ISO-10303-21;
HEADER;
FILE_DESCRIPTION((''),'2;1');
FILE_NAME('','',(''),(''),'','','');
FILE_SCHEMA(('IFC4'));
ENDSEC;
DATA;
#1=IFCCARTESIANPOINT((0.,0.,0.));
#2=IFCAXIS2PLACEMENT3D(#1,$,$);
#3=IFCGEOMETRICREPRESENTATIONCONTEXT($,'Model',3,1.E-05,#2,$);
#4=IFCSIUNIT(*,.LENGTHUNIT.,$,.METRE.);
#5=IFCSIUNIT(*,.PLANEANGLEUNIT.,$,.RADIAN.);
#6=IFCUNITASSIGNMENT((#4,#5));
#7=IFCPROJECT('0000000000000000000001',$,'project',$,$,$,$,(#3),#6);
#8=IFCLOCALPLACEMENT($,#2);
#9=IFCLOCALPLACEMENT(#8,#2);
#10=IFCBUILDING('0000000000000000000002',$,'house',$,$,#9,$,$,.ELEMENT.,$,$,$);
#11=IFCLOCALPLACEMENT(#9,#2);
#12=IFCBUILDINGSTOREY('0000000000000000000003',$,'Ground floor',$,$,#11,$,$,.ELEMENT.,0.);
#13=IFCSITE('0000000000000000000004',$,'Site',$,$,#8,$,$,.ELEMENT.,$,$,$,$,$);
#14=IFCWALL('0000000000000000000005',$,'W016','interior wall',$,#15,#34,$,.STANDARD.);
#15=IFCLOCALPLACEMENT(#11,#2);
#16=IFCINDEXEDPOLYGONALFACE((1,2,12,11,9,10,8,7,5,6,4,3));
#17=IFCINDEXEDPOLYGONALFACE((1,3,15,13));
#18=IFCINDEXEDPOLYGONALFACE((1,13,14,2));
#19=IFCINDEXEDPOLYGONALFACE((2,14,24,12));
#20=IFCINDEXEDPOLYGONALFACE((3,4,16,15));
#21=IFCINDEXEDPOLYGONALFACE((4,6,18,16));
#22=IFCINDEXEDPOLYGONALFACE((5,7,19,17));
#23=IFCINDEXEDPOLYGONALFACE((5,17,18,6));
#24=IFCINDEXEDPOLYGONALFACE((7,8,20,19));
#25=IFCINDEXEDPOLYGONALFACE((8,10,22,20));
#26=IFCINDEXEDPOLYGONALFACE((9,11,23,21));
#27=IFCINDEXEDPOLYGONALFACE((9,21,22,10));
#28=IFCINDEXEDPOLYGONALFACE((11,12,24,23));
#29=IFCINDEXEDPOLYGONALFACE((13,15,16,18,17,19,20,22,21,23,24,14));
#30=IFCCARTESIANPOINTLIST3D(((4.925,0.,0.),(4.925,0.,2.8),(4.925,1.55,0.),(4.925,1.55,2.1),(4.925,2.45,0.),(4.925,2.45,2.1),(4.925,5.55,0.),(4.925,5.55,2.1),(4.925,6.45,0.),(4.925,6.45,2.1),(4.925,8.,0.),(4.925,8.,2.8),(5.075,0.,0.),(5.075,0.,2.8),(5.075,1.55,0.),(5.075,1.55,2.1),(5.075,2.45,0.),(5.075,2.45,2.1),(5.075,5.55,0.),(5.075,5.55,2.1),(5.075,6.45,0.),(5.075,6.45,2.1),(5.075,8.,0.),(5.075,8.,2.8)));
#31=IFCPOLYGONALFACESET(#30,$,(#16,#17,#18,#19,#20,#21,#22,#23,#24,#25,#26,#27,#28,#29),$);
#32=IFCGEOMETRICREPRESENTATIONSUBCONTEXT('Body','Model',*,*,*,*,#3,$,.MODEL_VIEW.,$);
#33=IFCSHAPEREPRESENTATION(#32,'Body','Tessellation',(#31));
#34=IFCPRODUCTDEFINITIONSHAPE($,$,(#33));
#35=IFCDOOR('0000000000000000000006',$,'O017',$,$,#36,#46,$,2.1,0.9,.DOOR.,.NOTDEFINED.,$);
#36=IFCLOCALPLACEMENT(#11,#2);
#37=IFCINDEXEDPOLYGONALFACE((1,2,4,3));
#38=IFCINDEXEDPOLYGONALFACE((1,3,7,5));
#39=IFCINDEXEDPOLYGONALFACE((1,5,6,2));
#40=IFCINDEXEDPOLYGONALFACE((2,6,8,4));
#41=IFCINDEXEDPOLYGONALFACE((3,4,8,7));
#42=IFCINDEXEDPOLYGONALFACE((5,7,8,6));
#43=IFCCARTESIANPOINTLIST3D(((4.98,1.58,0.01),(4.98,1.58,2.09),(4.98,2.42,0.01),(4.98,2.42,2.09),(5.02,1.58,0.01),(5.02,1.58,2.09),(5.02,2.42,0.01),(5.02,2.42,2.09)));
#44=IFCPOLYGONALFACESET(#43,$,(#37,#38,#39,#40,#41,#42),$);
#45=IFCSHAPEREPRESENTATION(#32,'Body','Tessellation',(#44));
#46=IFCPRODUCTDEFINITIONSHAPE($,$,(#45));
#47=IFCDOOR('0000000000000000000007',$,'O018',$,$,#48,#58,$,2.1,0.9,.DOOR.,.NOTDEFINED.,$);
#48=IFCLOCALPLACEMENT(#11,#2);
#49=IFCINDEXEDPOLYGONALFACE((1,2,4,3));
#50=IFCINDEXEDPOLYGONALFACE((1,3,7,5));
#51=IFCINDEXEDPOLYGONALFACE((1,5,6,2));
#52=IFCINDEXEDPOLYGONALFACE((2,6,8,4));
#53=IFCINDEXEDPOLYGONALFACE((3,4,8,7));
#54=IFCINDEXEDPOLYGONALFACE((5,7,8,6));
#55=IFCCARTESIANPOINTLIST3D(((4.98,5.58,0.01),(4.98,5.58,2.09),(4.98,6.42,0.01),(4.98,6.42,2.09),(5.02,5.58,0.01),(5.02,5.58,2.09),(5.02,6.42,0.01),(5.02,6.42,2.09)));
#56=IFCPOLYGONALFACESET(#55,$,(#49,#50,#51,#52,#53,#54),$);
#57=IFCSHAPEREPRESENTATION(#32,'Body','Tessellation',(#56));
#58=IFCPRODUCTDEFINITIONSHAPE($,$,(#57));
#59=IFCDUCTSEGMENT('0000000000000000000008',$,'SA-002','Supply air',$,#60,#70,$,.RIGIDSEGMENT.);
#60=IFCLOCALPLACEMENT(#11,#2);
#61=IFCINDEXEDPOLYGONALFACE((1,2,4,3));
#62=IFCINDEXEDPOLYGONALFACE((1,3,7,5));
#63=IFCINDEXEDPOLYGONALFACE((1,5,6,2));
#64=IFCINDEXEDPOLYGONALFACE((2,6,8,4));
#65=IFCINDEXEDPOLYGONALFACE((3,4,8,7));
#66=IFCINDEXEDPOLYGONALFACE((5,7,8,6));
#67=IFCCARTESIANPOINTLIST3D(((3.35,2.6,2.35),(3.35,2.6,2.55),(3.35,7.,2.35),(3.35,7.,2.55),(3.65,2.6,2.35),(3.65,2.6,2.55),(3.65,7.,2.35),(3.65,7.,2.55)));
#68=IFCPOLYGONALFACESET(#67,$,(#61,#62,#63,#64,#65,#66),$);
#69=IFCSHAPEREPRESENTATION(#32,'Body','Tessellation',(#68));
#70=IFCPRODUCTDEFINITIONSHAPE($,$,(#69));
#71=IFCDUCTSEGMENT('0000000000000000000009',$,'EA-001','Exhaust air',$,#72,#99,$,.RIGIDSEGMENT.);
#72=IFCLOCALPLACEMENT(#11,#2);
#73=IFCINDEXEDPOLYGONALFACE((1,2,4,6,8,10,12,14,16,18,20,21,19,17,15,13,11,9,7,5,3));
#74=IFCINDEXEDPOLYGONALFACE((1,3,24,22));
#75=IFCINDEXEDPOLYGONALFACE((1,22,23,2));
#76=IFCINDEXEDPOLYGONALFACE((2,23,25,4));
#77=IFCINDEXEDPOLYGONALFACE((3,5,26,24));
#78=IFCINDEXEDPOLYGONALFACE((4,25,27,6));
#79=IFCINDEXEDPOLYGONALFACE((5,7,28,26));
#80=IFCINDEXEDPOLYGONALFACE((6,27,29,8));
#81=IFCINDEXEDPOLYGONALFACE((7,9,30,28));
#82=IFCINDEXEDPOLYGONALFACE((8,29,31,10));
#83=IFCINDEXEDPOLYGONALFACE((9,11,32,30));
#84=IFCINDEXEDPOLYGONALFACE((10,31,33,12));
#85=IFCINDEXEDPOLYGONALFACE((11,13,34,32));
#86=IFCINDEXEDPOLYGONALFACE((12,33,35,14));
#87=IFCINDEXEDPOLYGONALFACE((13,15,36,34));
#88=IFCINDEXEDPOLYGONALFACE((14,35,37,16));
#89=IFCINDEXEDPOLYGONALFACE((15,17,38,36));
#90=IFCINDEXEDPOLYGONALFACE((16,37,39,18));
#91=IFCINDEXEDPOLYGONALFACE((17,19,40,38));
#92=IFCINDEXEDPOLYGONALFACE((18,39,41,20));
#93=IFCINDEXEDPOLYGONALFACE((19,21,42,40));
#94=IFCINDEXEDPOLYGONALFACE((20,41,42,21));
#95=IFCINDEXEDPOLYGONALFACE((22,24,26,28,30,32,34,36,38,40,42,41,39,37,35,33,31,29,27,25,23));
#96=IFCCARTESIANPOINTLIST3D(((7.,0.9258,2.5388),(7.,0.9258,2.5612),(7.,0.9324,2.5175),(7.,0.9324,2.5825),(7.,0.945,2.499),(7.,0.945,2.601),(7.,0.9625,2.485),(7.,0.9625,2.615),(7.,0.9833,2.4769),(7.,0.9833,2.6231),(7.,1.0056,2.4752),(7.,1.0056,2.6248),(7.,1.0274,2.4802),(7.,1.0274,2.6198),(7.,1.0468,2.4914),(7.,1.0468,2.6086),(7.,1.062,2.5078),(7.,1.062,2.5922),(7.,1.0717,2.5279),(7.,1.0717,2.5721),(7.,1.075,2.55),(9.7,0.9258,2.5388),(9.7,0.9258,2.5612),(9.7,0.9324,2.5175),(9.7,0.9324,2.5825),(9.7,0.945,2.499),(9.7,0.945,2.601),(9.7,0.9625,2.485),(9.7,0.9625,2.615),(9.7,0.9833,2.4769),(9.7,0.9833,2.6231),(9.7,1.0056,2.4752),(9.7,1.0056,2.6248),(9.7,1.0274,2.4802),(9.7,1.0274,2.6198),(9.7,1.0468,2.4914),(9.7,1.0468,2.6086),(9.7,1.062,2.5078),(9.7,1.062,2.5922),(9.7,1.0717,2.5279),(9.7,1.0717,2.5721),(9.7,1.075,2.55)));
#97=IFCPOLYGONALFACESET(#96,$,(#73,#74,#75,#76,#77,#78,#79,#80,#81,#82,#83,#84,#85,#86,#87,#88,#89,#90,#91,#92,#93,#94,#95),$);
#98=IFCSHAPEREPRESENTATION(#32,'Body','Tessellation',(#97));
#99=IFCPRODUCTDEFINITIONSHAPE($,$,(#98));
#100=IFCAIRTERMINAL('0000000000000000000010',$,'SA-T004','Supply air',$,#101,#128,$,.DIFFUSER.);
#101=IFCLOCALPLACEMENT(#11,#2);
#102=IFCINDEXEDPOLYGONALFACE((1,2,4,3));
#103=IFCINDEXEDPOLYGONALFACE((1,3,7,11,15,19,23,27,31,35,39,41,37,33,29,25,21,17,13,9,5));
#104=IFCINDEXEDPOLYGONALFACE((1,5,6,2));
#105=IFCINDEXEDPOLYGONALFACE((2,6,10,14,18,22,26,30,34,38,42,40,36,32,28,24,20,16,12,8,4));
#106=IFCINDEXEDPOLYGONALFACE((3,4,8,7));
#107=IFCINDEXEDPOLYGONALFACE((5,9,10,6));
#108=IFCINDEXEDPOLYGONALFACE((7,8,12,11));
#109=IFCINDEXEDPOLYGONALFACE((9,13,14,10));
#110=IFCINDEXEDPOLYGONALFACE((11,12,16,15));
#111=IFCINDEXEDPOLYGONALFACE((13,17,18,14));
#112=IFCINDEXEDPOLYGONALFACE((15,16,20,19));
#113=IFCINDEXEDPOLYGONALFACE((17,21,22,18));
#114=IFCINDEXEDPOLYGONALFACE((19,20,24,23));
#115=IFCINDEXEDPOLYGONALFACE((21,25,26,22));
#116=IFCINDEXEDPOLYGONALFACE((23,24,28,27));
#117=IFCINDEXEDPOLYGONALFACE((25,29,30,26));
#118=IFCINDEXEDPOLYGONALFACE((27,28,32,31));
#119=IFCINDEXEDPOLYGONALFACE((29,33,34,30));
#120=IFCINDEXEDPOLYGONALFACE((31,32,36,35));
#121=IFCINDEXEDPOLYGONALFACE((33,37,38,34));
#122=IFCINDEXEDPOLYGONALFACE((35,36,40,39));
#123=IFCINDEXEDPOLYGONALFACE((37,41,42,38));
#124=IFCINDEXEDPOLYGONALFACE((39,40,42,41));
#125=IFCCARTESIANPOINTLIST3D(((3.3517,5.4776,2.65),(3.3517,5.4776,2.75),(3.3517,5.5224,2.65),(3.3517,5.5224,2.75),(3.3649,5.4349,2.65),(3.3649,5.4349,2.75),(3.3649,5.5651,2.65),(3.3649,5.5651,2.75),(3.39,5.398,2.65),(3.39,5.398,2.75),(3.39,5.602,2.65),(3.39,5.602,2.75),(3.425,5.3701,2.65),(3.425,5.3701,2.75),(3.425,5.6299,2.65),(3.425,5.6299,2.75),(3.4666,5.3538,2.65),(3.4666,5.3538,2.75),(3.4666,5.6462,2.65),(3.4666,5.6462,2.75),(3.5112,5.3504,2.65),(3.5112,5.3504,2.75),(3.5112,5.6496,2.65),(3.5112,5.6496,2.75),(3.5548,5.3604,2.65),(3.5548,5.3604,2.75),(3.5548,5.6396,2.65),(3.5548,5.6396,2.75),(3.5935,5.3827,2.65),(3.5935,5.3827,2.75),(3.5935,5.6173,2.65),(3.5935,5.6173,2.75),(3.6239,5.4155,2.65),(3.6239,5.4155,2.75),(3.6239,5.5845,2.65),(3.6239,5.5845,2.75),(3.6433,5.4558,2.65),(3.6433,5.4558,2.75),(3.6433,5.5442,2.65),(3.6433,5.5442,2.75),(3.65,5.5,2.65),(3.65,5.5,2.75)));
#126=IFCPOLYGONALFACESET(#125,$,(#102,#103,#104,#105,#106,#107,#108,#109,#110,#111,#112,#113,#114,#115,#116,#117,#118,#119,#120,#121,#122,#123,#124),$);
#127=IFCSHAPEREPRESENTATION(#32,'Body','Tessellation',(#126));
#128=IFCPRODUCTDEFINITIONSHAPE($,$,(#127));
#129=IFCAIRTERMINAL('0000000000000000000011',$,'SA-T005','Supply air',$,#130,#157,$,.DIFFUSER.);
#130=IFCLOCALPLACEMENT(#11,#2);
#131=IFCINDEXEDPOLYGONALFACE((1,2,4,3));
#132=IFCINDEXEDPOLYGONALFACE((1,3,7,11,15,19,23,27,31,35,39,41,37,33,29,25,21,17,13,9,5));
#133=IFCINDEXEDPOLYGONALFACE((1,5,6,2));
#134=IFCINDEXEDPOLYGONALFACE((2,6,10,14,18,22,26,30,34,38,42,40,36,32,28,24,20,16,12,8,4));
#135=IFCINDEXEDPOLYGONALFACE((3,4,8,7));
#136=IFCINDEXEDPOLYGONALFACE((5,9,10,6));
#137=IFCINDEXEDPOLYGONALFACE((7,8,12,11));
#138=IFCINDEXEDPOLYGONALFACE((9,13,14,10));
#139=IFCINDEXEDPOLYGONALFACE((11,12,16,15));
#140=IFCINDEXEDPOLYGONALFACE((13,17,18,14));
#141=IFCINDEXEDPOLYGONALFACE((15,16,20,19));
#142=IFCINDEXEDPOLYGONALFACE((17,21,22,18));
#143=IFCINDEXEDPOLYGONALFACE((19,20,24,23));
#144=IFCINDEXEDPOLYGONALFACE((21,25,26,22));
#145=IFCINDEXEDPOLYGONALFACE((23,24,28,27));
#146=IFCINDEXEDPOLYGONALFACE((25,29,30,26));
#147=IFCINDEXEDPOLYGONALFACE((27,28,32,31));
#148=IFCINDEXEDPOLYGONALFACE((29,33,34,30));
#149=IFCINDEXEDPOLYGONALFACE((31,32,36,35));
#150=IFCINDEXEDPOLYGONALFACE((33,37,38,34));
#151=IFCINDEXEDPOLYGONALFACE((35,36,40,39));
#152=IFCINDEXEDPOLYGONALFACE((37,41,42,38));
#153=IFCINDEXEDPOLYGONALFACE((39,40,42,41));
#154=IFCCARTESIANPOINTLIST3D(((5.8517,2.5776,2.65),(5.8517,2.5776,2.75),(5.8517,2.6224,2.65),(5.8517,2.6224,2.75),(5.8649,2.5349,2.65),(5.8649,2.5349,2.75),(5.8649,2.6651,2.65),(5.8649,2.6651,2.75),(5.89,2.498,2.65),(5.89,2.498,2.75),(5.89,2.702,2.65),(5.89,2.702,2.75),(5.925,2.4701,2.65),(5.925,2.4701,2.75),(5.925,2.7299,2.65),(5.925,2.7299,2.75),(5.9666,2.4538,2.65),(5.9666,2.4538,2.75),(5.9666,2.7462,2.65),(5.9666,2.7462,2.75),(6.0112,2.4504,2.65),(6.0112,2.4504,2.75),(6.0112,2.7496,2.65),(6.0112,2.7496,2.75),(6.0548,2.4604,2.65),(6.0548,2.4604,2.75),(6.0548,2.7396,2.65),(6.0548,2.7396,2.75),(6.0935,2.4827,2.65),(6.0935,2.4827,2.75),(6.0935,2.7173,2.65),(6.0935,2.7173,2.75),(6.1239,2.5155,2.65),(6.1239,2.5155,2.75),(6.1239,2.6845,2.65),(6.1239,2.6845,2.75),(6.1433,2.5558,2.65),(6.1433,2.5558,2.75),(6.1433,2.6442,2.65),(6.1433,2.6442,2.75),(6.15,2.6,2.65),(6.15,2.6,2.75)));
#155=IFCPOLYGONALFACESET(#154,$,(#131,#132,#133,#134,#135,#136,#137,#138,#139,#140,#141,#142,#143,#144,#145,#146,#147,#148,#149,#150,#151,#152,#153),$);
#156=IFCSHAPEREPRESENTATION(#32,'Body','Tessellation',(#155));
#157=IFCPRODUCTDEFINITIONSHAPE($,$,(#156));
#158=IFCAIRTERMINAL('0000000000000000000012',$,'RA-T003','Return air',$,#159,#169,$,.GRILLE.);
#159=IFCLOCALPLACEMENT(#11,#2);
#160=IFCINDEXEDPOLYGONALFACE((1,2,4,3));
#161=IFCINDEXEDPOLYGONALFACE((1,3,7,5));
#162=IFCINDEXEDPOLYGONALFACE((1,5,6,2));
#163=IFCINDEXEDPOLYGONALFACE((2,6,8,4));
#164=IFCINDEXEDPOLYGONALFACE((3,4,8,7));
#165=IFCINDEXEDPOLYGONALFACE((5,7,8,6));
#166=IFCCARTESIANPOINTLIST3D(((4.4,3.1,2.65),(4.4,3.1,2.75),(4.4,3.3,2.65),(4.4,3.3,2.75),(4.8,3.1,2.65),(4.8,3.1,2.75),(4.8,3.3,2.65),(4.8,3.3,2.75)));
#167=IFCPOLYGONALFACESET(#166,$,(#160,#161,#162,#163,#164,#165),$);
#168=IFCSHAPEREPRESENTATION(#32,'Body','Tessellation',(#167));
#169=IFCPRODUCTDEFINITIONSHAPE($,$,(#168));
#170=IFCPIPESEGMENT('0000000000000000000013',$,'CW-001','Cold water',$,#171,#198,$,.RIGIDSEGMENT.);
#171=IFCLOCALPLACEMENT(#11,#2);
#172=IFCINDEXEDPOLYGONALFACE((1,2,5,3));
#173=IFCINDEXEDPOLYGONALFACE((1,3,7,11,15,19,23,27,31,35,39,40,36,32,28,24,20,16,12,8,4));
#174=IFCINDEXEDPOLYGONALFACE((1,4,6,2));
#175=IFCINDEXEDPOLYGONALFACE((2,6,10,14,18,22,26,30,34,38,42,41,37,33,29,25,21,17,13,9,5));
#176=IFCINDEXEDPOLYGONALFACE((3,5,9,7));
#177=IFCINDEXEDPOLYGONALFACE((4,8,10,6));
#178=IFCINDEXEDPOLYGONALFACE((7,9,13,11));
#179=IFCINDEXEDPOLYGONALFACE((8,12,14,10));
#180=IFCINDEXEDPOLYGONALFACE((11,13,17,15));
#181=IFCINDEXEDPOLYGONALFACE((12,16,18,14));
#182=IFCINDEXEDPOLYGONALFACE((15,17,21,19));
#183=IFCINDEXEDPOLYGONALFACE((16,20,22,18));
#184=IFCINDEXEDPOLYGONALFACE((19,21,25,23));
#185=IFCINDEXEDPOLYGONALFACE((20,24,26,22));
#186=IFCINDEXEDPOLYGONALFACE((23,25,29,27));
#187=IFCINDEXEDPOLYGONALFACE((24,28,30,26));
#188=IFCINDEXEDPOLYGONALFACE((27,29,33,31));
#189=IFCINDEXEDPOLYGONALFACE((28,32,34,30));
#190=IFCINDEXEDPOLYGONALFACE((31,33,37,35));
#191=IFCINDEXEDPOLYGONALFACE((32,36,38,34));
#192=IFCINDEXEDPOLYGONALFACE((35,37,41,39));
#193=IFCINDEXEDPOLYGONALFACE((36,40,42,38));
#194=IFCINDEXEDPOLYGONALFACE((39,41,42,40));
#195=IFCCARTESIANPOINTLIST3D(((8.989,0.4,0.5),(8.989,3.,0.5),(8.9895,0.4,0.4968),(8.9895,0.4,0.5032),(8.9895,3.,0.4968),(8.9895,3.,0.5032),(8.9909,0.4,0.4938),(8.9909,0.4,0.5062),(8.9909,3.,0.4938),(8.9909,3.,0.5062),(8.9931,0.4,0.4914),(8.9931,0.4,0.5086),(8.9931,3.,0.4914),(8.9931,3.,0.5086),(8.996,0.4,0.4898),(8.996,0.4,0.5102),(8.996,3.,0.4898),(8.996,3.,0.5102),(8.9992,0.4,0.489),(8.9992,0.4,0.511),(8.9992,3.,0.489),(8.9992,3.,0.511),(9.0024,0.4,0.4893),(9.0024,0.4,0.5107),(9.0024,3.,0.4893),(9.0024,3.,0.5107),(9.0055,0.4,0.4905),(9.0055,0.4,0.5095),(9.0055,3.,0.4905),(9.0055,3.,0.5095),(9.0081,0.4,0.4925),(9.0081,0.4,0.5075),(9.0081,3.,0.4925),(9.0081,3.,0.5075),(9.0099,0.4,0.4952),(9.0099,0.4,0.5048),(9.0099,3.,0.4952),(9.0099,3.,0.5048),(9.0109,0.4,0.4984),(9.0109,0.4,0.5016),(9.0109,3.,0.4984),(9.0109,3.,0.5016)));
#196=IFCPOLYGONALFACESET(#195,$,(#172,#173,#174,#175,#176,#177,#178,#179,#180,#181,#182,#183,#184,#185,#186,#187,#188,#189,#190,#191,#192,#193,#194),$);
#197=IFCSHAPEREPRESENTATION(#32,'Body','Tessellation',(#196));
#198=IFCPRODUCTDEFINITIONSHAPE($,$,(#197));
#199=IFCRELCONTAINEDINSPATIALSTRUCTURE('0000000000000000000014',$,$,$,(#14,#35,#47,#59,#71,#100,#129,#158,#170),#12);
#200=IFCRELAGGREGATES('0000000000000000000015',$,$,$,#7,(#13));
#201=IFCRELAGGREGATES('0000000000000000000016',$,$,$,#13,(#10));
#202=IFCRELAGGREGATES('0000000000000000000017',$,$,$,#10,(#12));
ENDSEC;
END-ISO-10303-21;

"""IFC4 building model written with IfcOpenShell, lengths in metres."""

from ifc_helpers import new_model, si_unit, frame, origin, origin_2d, place, context, subcontext, project, spatial, rectangle, circle, extrude, element, fill, save


model = new_model("IFC4")

# Units and contexts
model_context = context("Model", 3, precision=1e-05, world=origin())
body_context = subcontext(model_context, "Body", "Model", "MODEL_VIEW")
ifc_project = project(units=[si_unit("LENGTHUNIT", "METRE"), si_unit("PLANEANGLEUNIT", "RADIAN")], contexts=[model_context])

# Site, building, storey
site_placement = place(None, origin())
site = spatial("IfcSite", under=ifc_project, at=site_placement, Name="Site", CompositionType="ELEMENT")
building_placement = place(site_placement, origin())
building = spatial("IfcBuilding", under=site, at=building_placement, Name="house", CompositionType="ELEMENT")
storey_placement = place(building_placement, origin())
storey = spatial("IfcBuildingStorey", under=building, at=storey_placement, Name="Ground floor", CompositionType="ELEMENT", Elevation=0.0)

# Wall, openings, doors
wall_1_placement = place(storey_placement, frame((5.0, 4.0, 0.0), z_axis=(0.0, 0.0, 1.0), x_axis=(0.0, 1.0, 0.0)))
wall_1 = element("IfcWall", 1, at=wall_1_placement, inside=storey, Name="W016", Description="interior wall", PredefinedType="STANDARD", context=body_context, shape_type="SweptSolid", body=[
    extrude(rectangle(XDim=8.0, YDim=0.15, at=origin_2d()), origin(), (0.0, 0.0, 1.0), 2.8),
])
opening_1_placement = place(wall_1_placement, frame((-2.0, 0.0, 0.0)))
opening_1 = element("IfcOpeningElement", 2, at=opening_1_placement, cuts=wall_1, PredefinedType="OPENING", context=body_context, shape_type="SweptSolid", body=[
    extrude(rectangle(XDim=0.9, YDim=0.18, at=origin_2d()), origin(), (0.0, 0.0, 1.0), 2.1),
])
opening_2_placement = place(wall_1_placement, frame((2.0, 0.0, 0.0)))
opening_2 = element("IfcOpeningElement", 3, at=opening_2_placement, cuts=wall_1, PredefinedType="OPENING", context=body_context, shape_type="SweptSolid", body=[
    extrude(rectangle(XDim=0.9, YDim=0.18, at=origin_2d()), origin(), (0.0, 0.0, 1.0), 2.1),
])
door_1_placement = place(wall_1_placement, frame((-2.0, 0.0, 0.0)))
door_1 = element("IfcDoor", 4, at=door_1_placement, inside=storey, Name="O017", OperationType="NOTDEFINED", OverallHeight=2.1, OverallWidth=0.9, PredefinedType="DOOR", context=body_context, shape_type="SweptSolid", body=[
    extrude(rectangle(XDim=0.84, YDim=0.04, at=origin_2d()), frame((0.0, 0.0, 0.01)), (0.0, 0.0, 1.0), 2.08),
])
fill(opening_1, door_1)
door_2_placement = place(wall_1_placement, frame((2.0, 0.0, 0.0)))
door_2 = element("IfcDoor", 5, at=door_2_placement, inside=storey, Name="O018", OperationType="NOTDEFINED", OverallHeight=2.1, OverallWidth=0.9, PredefinedType="DOOR", context=body_context, shape_type="SweptSolid", body=[
    extrude(rectangle(XDim=0.84, YDim=0.04, at=origin_2d()), frame((0.0, 0.0, 0.01)), (0.0, 0.0, 1.0), 2.08),
])
fill(opening_2, door_2)

# Duct segments
duct_segment_1_placement = place(storey_placement, frame((3.5, 2.6, 2.45), z_axis=(0.0, 1.0, 0.0), x_axis=(-1.0, 0.0, 0.0)))
element("IfcDuctSegment", 6, at=duct_segment_1_placement, inside=storey, Name="SA-002", Description="Supply air", PredefinedType="RIGIDSEGMENT", context=body_context, shape_type="SweptSolid", body=[
    extrude(rectangle(XDim=0.3, YDim=0.2, at=origin_2d()), origin(), (0.0, 0.0, 1.0), 4.4),
])
duct_segment_2_placement = place(storey_placement, frame((7.0, 1.0, 2.55), z_axis=(1.0, 0.0, 0.0), x_axis=(0.0, 1.0, 0.0)))
element("IfcDuctSegment", 7, at=duct_segment_2_placement, inside=storey, Name="EA-001", Description="Exhaust air", PredefinedType="RIGIDSEGMENT", context=body_context, shape_type="SweptSolid", body=[
    extrude(circle(Radius=0.075, at=origin_2d()), origin(), (0.0, 0.0, 1.0), 2.7),
])

# Air terminals
for number, where, z_axis, x_axis, name in (
    (8, (3.5, 5.5, 2.65), (0.0, 0.0, 1.0), (1.0, 0.0, 0.0), "SA-T004"),
    (9, (6.0, 2.6, 2.65), (0.0, 0.0, 1.0), (1.0, 0.0, 0.0), "SA-T005"),
):
    element("IfcAirTerminal", number, at=place(storey_placement, frame(where, z_axis=z_axis, x_axis=x_axis)), inside=storey, Name=name, Description="Supply air", PredefinedType="DIFFUSER", context=body_context, shape_type="SweptSolid", body=[
        extrude(circle(Radius=0.15, at=origin_2d()), origin(), (0.0, 0.0, 1.0), 0.1),
    ])
air_terminal_placement = place(storey_placement, frame((4.6, 3.2, 2.65), z_axis=(0.0, 0.0, 1.0), x_axis=(1.0, 0.0, 0.0)))
element("IfcAirTerminal", 10, at=air_terminal_placement, inside=storey, Name="RA-T003", Description="Return air", PredefinedType="GRILLE", context=body_context, shape_type="SweptSolid", body=[
    extrude(rectangle(XDim=0.4, YDim=0.2, at=origin_2d()), origin(), (0.0, 0.0, 1.0), 0.1),
])

# Pipe segment
pipe_segment_1_placement = place(storey_placement, frame((9.0, 0.4, 0.5), z_axis=(0.0, 1.0, 0.0), x_axis=(-1.0, 0.0, 0.0)))
element("IfcPipeSegment", 11, at=pipe_segment_1_placement, inside=storey, Name="CW-001", Description="Cold water", PredefinedType="RIGIDSEGMENT", context=body_context, shape_type="SweptSolid", body=[
    extrude(circle(Radius=0.011, at=origin_2d()), origin(), (0.0, 0.0, 1.0), 2.6),
])

save(model, "model.ifc")
